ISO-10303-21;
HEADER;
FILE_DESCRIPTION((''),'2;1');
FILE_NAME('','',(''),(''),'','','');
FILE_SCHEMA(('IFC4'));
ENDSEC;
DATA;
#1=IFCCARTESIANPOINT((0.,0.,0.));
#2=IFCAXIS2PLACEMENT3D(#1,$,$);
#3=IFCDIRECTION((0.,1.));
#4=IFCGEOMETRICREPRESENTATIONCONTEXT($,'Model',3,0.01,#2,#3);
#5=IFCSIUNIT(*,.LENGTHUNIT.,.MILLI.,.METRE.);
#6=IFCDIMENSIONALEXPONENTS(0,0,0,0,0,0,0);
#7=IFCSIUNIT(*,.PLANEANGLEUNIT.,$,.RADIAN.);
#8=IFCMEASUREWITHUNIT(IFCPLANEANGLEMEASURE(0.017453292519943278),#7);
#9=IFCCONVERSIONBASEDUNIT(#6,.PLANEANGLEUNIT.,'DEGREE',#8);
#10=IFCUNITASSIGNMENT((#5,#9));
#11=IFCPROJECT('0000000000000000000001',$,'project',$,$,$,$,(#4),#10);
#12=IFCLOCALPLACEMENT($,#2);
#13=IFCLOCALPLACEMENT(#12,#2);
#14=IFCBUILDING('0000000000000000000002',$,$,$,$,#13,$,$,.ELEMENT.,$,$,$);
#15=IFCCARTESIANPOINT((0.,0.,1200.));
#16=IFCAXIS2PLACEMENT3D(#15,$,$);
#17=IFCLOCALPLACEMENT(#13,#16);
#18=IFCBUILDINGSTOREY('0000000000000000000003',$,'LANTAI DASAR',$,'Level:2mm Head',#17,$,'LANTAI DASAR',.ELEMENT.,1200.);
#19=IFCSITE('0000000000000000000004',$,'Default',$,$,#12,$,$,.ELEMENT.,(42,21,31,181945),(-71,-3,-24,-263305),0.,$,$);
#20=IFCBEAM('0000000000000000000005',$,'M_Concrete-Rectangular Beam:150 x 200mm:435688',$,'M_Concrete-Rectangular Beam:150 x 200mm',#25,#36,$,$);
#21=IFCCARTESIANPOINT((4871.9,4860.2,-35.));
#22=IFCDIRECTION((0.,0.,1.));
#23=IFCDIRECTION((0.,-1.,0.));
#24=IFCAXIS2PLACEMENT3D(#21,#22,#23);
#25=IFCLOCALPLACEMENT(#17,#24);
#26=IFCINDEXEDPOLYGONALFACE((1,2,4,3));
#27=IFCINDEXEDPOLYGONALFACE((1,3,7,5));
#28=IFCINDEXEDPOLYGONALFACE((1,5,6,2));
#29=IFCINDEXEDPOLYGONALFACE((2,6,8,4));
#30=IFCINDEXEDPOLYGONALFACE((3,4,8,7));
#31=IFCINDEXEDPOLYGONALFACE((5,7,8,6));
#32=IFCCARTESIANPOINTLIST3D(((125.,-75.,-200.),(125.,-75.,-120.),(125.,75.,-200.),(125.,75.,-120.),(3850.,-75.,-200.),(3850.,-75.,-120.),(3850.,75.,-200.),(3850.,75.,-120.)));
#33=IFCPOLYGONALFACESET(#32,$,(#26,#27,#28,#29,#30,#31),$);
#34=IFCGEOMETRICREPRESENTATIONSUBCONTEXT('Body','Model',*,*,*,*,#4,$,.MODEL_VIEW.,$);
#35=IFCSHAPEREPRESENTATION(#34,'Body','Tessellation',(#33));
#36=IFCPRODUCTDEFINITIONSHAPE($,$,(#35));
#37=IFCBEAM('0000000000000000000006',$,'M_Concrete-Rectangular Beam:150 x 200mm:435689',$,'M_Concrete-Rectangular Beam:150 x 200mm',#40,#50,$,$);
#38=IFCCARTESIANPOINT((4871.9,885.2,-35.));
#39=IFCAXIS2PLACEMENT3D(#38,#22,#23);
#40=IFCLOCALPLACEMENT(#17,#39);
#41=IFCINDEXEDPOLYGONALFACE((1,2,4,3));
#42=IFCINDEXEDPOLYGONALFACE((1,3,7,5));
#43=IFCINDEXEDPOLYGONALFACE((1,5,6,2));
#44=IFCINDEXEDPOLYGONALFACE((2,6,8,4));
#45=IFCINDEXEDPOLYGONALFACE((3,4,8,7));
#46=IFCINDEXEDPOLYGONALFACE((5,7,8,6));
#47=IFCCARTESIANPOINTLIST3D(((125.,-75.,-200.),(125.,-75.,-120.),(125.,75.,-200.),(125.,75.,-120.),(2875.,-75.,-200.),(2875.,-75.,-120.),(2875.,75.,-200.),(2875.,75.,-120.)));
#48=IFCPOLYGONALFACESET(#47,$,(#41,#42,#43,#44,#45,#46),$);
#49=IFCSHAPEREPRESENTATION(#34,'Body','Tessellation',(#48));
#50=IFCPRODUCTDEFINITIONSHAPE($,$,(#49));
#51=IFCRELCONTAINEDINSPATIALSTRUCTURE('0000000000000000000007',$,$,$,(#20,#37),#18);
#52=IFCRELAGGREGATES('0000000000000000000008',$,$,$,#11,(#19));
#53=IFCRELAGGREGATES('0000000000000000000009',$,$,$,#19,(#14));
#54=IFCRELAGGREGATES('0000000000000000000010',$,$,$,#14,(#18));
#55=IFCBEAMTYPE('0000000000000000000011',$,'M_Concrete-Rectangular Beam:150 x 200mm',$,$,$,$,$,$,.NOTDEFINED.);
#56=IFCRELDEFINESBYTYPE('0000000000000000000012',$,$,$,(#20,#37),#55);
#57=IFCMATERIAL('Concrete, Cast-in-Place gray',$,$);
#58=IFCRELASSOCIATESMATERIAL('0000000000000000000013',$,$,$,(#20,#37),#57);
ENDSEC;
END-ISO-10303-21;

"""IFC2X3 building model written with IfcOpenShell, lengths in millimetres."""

from ifc_helpers import new_model, entity, si_unit, converted_unit, direction, frame, frame_2d, origin, place, context, subcontext, project, spatial, rectangle, extrude, material, type_object, element, save


model = new_model("IFC2X3")

# Units and contexts
model_context = context("Model", 3, precision=0.01, world=origin(), true_north=direction((0.0, 1.0)))
body_context = subcontext(model_context, "Body", "Model", "MODEL_VIEW")
ifc_project = project(units=[si_unit("LENGTHUNIT", "METRE", prefix="MILLI"), converted_unit("PLANEANGLEUNIT", "DEGREE", entity("IfcPlaneAngleMeasure", 0.017453292519943278), si_unit("PLANEANGLEUNIT", "RADIAN"), dimensions=[0, 0, 0, 0, 0, 0, 0])], contexts=[model_context])

# Site, building, storey
site_placement = place(None, origin())
site = spatial("IfcSite", under=ifc_project, at=site_placement, Name="Default", CompositionType="ELEMENT", RefLatitude=(42, 21, 31, 181945), RefLongitude=(-71, -3, -24, -263305), RefElevation=0.0)
building_placement = place(site_placement, origin())
building = spatial("IfcBuilding", under=site, at=building_placement, CompositionType="ELEMENT")
storey_placement = place(building_placement, frame((0.0, 0.0, 1200.0)))
storey = spatial("IfcBuildingStorey", under=building, at=storey_placement, Name="LANTAI DASAR", ObjectType="Level:2mm Head", LongName="LANTAI DASAR", CompositionType="ELEMENT", Elevation=1200.0)

# Shared definitions
ifc_material = material(Name="Concrete, Cast-in-Place gray")

# Beams
beam_type = type_object("IfcBeamType", Name="M_Concrete-Rectangular Beam:150 x 200mm", PredefinedType="NOTDEFINED")
beam_1_placement = place(storey_placement, frame((4871.9, 4860.2, -35.0), z_axis=(0.0, 0.0, 1.0), x_axis=(0.0, -1.0, 0.0)))
element("IfcBeam", 1, at=beam_1_placement, inside=storey, type_object=beam_type, material=ifc_material, Name="M_Concrete-Rectangular Beam:150 x 200mm:435688", ObjectType="M_Concrete-Rectangular Beam:150 x 200mm", context=body_context, shape_type="SweptSolid", body=[
    extrude(rectangle(XDim=80.0, YDim=150.0, at=frame_2d((0.0, 0.0), x_axis=(1.0, 0.0))), frame((125.0, 0.0, -160.0), z_axis=(1.0, 0.0, 0.0), x_axis=(0.0, 0.0, -1.0)), (0.0, 0.0, 1.0), 3725.0),
])
beam_2_placement = place(storey_placement, frame((4871.9, 885.2, -35.0), z_axis=(0.0, 0.0, 1.0), x_axis=(0.0, -1.0, 0.0)))
element("IfcBeam", 2, at=beam_2_placement, inside=storey, type_object=beam_type, material=ifc_material, Name="M_Concrete-Rectangular Beam:150 x 200mm:435689", ObjectType="M_Concrete-Rectangular Beam:150 x 200mm", context=body_context, shape_type="SweptSolid", body=[
    extrude(rectangle(XDim=80.0, YDim=150.0, at=frame_2d((0.0, 0.0), x_axis=(1.0, 0.0))), frame((125.0, 0.0, -160.0), z_axis=(1.0, 0.0, 0.0), x_axis=(0.0, 0.0, -1.0)), (0.0, 0.0, 1.0), 2750.0),
])

save(model, "model.ifc")
